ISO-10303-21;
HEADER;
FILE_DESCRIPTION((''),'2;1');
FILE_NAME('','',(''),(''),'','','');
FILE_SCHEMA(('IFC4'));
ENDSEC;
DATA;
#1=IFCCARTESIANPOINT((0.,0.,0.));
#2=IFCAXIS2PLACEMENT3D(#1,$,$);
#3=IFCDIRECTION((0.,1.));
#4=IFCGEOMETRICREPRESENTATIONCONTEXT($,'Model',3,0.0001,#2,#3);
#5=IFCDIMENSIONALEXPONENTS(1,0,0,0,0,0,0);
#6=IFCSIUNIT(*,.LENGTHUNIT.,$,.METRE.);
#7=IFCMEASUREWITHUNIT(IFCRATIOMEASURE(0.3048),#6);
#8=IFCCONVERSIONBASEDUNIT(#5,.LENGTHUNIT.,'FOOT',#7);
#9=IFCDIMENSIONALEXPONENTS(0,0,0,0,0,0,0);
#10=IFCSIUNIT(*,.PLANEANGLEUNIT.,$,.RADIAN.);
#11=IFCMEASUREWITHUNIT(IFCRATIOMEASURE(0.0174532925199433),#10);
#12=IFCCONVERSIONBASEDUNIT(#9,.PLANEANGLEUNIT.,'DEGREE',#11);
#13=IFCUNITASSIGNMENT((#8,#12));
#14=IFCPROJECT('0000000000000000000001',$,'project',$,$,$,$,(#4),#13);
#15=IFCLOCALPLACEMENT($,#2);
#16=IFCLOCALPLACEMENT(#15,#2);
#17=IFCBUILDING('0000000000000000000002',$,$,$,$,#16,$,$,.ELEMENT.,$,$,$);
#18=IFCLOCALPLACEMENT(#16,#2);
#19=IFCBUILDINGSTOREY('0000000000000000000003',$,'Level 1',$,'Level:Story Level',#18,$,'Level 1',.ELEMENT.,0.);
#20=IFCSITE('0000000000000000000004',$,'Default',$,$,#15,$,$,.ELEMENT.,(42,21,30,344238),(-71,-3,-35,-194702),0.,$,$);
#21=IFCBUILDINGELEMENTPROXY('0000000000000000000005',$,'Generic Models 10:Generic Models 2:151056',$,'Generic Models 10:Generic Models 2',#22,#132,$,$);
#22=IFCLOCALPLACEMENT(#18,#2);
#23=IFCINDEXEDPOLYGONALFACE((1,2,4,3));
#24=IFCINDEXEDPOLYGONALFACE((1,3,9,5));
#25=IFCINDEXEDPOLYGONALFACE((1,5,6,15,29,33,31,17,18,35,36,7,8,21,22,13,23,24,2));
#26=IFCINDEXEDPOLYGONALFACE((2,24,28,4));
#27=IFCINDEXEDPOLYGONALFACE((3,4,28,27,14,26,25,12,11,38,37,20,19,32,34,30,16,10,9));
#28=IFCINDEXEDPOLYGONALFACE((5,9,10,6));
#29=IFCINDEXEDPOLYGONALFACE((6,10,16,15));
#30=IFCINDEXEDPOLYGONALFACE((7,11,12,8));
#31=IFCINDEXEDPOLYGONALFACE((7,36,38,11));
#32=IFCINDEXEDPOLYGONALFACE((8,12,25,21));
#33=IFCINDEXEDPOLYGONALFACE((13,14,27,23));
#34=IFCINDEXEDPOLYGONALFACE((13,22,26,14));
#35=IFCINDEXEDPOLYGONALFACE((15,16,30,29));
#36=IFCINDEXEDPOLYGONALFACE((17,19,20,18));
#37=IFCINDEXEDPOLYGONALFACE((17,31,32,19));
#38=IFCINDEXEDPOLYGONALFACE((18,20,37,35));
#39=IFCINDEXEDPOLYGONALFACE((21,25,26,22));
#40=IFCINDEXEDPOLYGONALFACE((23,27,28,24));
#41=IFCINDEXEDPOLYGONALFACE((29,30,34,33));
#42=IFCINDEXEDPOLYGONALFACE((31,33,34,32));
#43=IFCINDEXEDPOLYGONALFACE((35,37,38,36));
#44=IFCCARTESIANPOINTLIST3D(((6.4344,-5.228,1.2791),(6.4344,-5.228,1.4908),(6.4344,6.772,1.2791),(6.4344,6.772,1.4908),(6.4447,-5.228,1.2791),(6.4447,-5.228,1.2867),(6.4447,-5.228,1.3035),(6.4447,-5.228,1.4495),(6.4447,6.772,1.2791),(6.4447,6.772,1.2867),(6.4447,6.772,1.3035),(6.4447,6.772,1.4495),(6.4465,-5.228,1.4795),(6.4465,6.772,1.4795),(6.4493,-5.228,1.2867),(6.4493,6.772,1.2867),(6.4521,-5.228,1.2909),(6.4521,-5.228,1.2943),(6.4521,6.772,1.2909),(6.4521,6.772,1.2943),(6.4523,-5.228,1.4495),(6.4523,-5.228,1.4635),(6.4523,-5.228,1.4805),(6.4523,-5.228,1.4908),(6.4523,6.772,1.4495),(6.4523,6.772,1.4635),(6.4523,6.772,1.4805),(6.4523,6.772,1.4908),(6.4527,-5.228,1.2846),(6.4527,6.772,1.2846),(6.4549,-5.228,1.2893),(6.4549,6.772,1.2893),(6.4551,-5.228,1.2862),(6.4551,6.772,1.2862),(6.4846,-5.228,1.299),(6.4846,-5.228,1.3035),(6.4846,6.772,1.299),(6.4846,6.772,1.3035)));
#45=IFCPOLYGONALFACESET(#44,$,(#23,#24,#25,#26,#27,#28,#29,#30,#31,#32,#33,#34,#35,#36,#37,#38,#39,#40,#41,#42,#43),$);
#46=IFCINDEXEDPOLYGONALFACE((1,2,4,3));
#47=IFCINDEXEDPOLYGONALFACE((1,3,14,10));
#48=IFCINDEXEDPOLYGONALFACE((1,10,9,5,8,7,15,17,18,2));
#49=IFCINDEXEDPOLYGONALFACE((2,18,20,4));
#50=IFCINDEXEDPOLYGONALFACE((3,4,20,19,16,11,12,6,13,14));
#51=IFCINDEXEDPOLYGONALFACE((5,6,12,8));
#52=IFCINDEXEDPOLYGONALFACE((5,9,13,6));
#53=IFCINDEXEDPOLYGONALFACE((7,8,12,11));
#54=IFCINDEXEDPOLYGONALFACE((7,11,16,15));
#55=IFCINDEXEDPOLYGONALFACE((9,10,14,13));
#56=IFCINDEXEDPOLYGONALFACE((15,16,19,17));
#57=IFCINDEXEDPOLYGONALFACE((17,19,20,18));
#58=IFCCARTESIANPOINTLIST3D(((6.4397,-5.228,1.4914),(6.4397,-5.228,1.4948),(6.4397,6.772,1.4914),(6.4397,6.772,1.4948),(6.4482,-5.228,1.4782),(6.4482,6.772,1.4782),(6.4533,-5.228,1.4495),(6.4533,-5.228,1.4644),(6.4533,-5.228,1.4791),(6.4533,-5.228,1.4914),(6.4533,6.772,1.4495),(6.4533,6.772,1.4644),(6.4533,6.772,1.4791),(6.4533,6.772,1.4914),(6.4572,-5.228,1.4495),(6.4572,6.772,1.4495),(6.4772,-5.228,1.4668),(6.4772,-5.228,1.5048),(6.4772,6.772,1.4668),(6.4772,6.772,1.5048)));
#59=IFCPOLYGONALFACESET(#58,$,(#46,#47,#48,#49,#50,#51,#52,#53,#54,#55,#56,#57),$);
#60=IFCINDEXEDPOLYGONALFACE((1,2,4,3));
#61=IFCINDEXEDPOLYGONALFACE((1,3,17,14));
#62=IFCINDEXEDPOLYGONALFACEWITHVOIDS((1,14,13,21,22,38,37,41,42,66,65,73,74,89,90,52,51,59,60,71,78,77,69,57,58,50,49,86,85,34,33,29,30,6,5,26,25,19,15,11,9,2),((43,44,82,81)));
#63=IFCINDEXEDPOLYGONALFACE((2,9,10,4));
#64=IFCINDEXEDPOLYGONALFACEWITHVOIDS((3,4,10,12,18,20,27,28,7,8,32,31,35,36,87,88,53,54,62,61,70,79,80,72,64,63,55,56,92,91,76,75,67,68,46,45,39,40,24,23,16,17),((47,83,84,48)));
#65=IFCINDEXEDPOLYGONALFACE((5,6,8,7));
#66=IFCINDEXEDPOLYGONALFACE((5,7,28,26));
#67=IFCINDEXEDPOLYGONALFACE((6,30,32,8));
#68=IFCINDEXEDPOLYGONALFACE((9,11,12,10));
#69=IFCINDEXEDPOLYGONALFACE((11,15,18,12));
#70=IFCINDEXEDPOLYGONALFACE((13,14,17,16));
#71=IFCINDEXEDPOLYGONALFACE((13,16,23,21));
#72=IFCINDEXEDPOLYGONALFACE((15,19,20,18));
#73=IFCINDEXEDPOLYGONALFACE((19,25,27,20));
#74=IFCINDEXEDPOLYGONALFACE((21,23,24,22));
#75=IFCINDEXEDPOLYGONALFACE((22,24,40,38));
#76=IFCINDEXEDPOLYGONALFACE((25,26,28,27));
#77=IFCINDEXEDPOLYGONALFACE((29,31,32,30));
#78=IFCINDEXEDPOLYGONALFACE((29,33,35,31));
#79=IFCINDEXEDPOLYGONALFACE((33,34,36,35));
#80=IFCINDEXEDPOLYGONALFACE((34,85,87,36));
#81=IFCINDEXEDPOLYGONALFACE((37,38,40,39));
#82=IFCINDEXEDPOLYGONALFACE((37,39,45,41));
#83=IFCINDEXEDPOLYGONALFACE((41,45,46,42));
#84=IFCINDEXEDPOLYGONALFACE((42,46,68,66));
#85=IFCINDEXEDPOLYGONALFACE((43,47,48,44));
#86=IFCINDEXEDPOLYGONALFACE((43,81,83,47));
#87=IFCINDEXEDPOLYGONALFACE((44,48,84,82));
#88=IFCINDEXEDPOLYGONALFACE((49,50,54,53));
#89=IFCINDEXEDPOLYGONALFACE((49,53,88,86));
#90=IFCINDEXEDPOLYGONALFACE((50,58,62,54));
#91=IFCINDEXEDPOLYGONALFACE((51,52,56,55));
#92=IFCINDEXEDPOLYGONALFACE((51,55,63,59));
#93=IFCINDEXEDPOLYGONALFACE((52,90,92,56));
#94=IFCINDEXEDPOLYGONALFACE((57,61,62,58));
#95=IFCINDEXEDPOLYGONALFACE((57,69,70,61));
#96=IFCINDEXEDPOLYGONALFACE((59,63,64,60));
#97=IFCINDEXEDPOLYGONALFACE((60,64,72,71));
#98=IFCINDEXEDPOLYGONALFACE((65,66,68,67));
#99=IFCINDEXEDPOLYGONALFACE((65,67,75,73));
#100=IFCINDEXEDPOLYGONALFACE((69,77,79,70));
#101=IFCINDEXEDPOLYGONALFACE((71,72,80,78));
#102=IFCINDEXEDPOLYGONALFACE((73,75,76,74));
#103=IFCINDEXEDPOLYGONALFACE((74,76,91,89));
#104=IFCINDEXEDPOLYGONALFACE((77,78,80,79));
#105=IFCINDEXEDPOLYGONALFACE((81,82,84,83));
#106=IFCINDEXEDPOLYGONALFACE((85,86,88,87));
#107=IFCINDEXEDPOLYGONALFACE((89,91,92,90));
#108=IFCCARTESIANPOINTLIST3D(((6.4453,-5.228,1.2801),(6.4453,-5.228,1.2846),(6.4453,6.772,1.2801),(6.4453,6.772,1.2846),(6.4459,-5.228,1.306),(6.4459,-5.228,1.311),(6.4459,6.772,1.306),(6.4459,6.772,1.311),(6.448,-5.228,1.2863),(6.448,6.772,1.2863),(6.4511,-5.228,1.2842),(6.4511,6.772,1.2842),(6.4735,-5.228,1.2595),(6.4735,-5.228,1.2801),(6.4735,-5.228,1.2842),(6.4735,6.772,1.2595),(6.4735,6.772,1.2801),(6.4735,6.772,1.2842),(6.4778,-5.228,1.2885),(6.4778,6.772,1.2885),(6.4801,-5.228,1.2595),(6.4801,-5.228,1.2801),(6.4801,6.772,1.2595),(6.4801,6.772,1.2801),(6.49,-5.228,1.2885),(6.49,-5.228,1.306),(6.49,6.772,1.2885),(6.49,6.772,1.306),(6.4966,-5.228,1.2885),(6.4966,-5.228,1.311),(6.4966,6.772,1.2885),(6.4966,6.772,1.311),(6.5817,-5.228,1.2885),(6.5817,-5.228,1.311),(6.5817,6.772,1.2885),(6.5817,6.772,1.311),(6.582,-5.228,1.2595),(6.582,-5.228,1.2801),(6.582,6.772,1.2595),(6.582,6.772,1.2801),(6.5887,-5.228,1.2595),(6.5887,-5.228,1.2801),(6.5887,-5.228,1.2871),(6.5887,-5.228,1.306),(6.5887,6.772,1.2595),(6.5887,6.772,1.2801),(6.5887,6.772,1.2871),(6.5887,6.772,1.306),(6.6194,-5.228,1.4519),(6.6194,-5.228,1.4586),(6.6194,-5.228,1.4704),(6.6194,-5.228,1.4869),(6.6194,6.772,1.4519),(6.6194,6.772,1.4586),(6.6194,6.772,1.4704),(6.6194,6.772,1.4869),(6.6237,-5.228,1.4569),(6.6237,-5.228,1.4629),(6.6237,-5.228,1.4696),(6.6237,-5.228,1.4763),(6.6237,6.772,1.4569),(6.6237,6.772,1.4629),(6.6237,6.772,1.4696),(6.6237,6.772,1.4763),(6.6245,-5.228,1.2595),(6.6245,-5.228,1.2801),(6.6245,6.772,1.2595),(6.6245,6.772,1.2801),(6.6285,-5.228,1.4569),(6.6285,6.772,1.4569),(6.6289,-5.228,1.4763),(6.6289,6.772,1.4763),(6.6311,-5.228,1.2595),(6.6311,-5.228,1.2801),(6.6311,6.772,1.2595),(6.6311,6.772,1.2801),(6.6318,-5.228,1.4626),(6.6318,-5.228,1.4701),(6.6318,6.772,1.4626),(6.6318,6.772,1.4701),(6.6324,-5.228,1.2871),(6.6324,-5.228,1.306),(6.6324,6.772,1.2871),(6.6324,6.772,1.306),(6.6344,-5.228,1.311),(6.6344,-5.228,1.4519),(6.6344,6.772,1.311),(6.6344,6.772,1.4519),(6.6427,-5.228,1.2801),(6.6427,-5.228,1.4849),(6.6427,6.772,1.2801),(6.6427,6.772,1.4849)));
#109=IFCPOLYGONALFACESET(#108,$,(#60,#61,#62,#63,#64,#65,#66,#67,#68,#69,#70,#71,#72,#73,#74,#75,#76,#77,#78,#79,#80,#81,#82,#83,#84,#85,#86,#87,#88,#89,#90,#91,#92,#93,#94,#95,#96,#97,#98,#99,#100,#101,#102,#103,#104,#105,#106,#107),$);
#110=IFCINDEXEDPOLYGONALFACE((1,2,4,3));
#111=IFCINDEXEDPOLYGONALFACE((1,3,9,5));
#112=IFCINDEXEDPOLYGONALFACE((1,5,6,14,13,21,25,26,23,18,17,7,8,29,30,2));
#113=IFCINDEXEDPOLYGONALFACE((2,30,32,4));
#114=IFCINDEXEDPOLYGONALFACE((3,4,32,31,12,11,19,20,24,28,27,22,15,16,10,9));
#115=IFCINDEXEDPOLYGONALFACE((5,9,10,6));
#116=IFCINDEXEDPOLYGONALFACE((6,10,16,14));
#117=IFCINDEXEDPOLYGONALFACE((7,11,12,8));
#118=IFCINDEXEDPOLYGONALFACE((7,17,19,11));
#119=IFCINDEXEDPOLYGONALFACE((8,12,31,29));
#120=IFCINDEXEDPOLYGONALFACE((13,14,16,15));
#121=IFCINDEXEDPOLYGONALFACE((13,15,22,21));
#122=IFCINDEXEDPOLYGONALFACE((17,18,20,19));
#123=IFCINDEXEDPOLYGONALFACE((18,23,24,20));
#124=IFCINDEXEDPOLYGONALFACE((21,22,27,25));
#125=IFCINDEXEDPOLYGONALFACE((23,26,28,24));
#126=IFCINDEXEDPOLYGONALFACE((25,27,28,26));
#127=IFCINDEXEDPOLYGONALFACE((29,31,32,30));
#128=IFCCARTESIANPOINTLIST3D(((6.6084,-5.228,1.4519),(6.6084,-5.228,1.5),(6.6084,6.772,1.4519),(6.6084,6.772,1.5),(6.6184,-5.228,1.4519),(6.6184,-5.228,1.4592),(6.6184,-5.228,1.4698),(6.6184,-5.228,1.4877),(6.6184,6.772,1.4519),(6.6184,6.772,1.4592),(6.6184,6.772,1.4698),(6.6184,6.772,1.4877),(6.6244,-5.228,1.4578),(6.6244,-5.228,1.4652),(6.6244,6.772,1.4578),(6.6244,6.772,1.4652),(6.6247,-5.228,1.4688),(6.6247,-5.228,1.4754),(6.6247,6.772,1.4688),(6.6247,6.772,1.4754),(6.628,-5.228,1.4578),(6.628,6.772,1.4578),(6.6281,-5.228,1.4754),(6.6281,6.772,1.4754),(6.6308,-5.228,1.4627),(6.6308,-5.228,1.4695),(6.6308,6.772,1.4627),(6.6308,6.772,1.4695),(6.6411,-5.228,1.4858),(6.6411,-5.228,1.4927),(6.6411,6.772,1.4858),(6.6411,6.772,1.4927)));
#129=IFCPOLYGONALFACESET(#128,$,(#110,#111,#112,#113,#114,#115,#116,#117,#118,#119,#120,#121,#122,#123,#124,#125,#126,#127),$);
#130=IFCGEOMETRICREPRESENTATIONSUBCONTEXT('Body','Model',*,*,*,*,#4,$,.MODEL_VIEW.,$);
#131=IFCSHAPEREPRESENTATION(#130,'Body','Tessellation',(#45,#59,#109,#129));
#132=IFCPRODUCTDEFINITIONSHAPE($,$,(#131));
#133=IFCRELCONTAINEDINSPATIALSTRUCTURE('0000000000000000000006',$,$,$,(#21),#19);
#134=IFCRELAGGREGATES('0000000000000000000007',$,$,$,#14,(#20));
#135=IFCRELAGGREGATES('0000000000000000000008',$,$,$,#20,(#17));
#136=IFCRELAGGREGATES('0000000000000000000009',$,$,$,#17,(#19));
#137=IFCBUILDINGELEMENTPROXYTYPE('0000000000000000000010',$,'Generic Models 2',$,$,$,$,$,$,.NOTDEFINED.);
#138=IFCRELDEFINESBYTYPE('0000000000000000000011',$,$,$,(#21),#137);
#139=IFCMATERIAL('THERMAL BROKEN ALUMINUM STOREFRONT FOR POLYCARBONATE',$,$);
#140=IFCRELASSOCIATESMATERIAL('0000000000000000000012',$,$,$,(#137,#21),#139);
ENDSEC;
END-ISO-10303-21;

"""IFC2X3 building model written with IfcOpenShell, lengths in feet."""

from ifc_helpers import new_model, entity, si_unit, converted_unit, direction, frame, origin, place, context, subcontext, project, spatial, polyline, outline, extrude, source, transform, mapped, material, type_object, type_shapes, element, save


model = new_model("IFC2X3")

# Units and contexts
model_context = context("Model", 3, precision=0.0001, world=origin(), true_north=direction((0.0, 1.0)))
body_context = subcontext(model_context, "Body", "Model", "MODEL_VIEW")
ifc_project = project(units=[converted_unit("LENGTHUNIT", "FOOT", entity("IfcRatioMeasure", 0.3048), si_unit("LENGTHUNIT", "METRE"), dimensions=[1, 0, 0, 0, 0, 0, 0]), converted_unit("PLANEANGLEUNIT", "DEGREE", entity("IfcRatioMeasure", 0.0174532925199433), si_unit("PLANEANGLEUNIT", "RADIAN"), dimensions=[0, 0, 0, 0, 0, 0, 0])], contexts=[model_context])

# Site, building, storey
site_placement = place(None, origin())
site = spatial("IfcSite", under=ifc_project, at=site_placement, Name="Default", CompositionType="ELEMENT", RefLatitude=(42, 21, 30, 344238), RefLongitude=(-71, -3, -35, -194702), RefElevation=0.0)
building_placement = place(site_placement, origin())
building = spatial("IfcBuilding", under=site, at=building_placement, CompositionType="ELEMENT")
storey_placement = place(building_placement, origin())
storey = spatial("IfcBuildingStorey", under=building, at=storey_placement, Name="Level 1", ObjectType="Level:Story Level", LongName="Level 1", CompositionType="ELEMENT", Elevation=0.0)

# Building element proxy
ifc_material = material(Name="THERMAL BROKEN ALUMINUM STOREFRONT FOR POLYCARBONATE")
building_element_proxy_type_1 = type_object("IfcBuildingElementProxyType", Name="Generic Models 2", PredefinedType="NOTDEFINED", material=ifc_material)
shared_shape_1 = source(origin(), body_context, "Body", "SweptSolid", [
    extrude(outline(polyline([(0.068, 0.0006), (0.0711, 0.0006), (0.0726, 0.0031), (0.0702, 0.0064), (0.07, 0.011), (0.0776, 0.0114), (0.0771, 0.0217), (-0.1343, 0.0107), (-0.1334, -0.0072), (-0.1231, -0.0066), (-0.1224, -0.0008), (-0.1062, -0.0058), (-0.0922, -0.005), (-0.0926, 0.0025), (0.0533, 0.0101), (0.0554, -0.0297), (0.0599, -0.0295), (0.0628, 0.0032), (0.0663, 0.0034), (0.068, 0.0006)])), frame((0.0, 0.32, 0.0977), z_axis=(1.0, 0.0, 0.0), x_axis=(0.0, -0.051774, -0.998659)), (0.0, 0.0, 1.0), 12.0),
    extrude(outline(polyline([(-0.0104, -0.0212), (0.0284, -0.0212), (0.0186, 0.0156), (-0.0052, 0.0271), (-0.009, 0.026), (-0.0051, 0.0117), (-0.0065, -0.003), (-0.0014, -0.0025), (0.0018, -0.0144), (-0.0113, -0.0179), (-0.0104, -0.0212)])), frame((0.0, 0.3168, 0.2175), z_axis=(1.0, 0.0, 0.0), x_axis=(0.0, -0.966235, 0.257663)), (0.0, 0.0, 1.0), 12.0),
    extrude(outline(polyline([(-0.073, 0.107), (-0.058, 0.107), (-0.058, 0.1137), (-0.0623, 0.118), (-0.0623, 0.1121), (-0.0672, 0.1121), (-0.0704, 0.1177), (-0.0704, 0.1252), (-0.0675, 0.1315), (-0.0623, 0.1315), (-0.0623, 0.1248), (-0.058, 0.1255), (-0.058, 0.142), (-0.0814, 0.1401), (-0.0814, -0.0647), (-0.0697, -0.0647), (-0.0697, -0.0853), (-0.0631, -0.0853), (-0.0631, -0.0647), (-0.0273, -0.0647), (-0.0273, -0.0853), (-0.0207, -0.0853), (-0.0207, -0.0647), (0.0812, -0.0647), (0.0812, -0.0853), (0.0878, -0.0853), (0.0878, -0.0647), (0.1161, -0.0647), (0.1161, -0.0603), (0.1133, -0.0585), (0.1102, -0.0606), (0.0878, -0.0606), (0.0836, -0.0564), (0.0713, -0.0564), (0.0713, -0.0389), (0.1155, -0.0389), (0.1155, -0.0338), (0.0647, -0.0338), (0.0647, -0.0564), (-0.0203, -0.0564), (-0.0203, -0.0338), (-0.073, -0.0338), (-0.073, 0.107)]), holes=[polyline([(-0.0711, -0.0577), (-0.0711, -0.0389), (-0.0273, -0.0389), (-0.0273, -0.0577), (-0.0711, -0.0577)])]), frame((0.0, 0.2107, 0.0853), z_axis=(1.0, 0.0, 0.0), x_axis=(0.0, 1.0, 0.0)), (0.0, 0.0, 1.0), 12.0),
    extrude(outline(polyline([(-0.0218, -0.0251), (0.0116, -0.0251), (0.0131, -0.0183), (-0.0094, -0.0153), (-0.0056, 0.0021), (0.0008, 0.0018), (-0.0006, -0.0047), (0.0027, -0.0054), (0.0066, -0.0003), (0.0081, 0.0064), (0.0064, 0.0118), (0.0029, 0.0126), (0.0013, 0.0053), (-0.0032, 0.0125), (-0.0017, 0.0197), (-0.0114, 0.0218), (-0.0218, -0.0251)])), frame((0.0, 0.1478, 0.2112), z_axis=(1.0, 0.0, 0.0), x_axis=(0.0, -0.976068, -0.217466)), (0.0, 0.0, 1.0), 12.0),
])
type_shapes(building_element_proxy_type_1, [shared_shape_1])
proxy_1_placement = place(storey_placement, frame((6.772, -5.228, 1.2595), z_axis=(0.0, 0.0, 1.0), x_axis=(0.0, 1.0, 0.0)))
element("IfcBuildingElementProxy", 1, at=proxy_1_placement, inside=storey, type_object=building_element_proxy_type_1, material=ifc_material, Name="Generic Models 10:Generic Models 2:151056", ObjectType="Generic Models 10:Generic Models 2", context=body_context, shape_type="MappedRepresentation", body=[
    mapped(shared_shape_1, transform((0.0, 0.0, 0.0), scale=1.0)),
])

save(model, "model.ifc")
